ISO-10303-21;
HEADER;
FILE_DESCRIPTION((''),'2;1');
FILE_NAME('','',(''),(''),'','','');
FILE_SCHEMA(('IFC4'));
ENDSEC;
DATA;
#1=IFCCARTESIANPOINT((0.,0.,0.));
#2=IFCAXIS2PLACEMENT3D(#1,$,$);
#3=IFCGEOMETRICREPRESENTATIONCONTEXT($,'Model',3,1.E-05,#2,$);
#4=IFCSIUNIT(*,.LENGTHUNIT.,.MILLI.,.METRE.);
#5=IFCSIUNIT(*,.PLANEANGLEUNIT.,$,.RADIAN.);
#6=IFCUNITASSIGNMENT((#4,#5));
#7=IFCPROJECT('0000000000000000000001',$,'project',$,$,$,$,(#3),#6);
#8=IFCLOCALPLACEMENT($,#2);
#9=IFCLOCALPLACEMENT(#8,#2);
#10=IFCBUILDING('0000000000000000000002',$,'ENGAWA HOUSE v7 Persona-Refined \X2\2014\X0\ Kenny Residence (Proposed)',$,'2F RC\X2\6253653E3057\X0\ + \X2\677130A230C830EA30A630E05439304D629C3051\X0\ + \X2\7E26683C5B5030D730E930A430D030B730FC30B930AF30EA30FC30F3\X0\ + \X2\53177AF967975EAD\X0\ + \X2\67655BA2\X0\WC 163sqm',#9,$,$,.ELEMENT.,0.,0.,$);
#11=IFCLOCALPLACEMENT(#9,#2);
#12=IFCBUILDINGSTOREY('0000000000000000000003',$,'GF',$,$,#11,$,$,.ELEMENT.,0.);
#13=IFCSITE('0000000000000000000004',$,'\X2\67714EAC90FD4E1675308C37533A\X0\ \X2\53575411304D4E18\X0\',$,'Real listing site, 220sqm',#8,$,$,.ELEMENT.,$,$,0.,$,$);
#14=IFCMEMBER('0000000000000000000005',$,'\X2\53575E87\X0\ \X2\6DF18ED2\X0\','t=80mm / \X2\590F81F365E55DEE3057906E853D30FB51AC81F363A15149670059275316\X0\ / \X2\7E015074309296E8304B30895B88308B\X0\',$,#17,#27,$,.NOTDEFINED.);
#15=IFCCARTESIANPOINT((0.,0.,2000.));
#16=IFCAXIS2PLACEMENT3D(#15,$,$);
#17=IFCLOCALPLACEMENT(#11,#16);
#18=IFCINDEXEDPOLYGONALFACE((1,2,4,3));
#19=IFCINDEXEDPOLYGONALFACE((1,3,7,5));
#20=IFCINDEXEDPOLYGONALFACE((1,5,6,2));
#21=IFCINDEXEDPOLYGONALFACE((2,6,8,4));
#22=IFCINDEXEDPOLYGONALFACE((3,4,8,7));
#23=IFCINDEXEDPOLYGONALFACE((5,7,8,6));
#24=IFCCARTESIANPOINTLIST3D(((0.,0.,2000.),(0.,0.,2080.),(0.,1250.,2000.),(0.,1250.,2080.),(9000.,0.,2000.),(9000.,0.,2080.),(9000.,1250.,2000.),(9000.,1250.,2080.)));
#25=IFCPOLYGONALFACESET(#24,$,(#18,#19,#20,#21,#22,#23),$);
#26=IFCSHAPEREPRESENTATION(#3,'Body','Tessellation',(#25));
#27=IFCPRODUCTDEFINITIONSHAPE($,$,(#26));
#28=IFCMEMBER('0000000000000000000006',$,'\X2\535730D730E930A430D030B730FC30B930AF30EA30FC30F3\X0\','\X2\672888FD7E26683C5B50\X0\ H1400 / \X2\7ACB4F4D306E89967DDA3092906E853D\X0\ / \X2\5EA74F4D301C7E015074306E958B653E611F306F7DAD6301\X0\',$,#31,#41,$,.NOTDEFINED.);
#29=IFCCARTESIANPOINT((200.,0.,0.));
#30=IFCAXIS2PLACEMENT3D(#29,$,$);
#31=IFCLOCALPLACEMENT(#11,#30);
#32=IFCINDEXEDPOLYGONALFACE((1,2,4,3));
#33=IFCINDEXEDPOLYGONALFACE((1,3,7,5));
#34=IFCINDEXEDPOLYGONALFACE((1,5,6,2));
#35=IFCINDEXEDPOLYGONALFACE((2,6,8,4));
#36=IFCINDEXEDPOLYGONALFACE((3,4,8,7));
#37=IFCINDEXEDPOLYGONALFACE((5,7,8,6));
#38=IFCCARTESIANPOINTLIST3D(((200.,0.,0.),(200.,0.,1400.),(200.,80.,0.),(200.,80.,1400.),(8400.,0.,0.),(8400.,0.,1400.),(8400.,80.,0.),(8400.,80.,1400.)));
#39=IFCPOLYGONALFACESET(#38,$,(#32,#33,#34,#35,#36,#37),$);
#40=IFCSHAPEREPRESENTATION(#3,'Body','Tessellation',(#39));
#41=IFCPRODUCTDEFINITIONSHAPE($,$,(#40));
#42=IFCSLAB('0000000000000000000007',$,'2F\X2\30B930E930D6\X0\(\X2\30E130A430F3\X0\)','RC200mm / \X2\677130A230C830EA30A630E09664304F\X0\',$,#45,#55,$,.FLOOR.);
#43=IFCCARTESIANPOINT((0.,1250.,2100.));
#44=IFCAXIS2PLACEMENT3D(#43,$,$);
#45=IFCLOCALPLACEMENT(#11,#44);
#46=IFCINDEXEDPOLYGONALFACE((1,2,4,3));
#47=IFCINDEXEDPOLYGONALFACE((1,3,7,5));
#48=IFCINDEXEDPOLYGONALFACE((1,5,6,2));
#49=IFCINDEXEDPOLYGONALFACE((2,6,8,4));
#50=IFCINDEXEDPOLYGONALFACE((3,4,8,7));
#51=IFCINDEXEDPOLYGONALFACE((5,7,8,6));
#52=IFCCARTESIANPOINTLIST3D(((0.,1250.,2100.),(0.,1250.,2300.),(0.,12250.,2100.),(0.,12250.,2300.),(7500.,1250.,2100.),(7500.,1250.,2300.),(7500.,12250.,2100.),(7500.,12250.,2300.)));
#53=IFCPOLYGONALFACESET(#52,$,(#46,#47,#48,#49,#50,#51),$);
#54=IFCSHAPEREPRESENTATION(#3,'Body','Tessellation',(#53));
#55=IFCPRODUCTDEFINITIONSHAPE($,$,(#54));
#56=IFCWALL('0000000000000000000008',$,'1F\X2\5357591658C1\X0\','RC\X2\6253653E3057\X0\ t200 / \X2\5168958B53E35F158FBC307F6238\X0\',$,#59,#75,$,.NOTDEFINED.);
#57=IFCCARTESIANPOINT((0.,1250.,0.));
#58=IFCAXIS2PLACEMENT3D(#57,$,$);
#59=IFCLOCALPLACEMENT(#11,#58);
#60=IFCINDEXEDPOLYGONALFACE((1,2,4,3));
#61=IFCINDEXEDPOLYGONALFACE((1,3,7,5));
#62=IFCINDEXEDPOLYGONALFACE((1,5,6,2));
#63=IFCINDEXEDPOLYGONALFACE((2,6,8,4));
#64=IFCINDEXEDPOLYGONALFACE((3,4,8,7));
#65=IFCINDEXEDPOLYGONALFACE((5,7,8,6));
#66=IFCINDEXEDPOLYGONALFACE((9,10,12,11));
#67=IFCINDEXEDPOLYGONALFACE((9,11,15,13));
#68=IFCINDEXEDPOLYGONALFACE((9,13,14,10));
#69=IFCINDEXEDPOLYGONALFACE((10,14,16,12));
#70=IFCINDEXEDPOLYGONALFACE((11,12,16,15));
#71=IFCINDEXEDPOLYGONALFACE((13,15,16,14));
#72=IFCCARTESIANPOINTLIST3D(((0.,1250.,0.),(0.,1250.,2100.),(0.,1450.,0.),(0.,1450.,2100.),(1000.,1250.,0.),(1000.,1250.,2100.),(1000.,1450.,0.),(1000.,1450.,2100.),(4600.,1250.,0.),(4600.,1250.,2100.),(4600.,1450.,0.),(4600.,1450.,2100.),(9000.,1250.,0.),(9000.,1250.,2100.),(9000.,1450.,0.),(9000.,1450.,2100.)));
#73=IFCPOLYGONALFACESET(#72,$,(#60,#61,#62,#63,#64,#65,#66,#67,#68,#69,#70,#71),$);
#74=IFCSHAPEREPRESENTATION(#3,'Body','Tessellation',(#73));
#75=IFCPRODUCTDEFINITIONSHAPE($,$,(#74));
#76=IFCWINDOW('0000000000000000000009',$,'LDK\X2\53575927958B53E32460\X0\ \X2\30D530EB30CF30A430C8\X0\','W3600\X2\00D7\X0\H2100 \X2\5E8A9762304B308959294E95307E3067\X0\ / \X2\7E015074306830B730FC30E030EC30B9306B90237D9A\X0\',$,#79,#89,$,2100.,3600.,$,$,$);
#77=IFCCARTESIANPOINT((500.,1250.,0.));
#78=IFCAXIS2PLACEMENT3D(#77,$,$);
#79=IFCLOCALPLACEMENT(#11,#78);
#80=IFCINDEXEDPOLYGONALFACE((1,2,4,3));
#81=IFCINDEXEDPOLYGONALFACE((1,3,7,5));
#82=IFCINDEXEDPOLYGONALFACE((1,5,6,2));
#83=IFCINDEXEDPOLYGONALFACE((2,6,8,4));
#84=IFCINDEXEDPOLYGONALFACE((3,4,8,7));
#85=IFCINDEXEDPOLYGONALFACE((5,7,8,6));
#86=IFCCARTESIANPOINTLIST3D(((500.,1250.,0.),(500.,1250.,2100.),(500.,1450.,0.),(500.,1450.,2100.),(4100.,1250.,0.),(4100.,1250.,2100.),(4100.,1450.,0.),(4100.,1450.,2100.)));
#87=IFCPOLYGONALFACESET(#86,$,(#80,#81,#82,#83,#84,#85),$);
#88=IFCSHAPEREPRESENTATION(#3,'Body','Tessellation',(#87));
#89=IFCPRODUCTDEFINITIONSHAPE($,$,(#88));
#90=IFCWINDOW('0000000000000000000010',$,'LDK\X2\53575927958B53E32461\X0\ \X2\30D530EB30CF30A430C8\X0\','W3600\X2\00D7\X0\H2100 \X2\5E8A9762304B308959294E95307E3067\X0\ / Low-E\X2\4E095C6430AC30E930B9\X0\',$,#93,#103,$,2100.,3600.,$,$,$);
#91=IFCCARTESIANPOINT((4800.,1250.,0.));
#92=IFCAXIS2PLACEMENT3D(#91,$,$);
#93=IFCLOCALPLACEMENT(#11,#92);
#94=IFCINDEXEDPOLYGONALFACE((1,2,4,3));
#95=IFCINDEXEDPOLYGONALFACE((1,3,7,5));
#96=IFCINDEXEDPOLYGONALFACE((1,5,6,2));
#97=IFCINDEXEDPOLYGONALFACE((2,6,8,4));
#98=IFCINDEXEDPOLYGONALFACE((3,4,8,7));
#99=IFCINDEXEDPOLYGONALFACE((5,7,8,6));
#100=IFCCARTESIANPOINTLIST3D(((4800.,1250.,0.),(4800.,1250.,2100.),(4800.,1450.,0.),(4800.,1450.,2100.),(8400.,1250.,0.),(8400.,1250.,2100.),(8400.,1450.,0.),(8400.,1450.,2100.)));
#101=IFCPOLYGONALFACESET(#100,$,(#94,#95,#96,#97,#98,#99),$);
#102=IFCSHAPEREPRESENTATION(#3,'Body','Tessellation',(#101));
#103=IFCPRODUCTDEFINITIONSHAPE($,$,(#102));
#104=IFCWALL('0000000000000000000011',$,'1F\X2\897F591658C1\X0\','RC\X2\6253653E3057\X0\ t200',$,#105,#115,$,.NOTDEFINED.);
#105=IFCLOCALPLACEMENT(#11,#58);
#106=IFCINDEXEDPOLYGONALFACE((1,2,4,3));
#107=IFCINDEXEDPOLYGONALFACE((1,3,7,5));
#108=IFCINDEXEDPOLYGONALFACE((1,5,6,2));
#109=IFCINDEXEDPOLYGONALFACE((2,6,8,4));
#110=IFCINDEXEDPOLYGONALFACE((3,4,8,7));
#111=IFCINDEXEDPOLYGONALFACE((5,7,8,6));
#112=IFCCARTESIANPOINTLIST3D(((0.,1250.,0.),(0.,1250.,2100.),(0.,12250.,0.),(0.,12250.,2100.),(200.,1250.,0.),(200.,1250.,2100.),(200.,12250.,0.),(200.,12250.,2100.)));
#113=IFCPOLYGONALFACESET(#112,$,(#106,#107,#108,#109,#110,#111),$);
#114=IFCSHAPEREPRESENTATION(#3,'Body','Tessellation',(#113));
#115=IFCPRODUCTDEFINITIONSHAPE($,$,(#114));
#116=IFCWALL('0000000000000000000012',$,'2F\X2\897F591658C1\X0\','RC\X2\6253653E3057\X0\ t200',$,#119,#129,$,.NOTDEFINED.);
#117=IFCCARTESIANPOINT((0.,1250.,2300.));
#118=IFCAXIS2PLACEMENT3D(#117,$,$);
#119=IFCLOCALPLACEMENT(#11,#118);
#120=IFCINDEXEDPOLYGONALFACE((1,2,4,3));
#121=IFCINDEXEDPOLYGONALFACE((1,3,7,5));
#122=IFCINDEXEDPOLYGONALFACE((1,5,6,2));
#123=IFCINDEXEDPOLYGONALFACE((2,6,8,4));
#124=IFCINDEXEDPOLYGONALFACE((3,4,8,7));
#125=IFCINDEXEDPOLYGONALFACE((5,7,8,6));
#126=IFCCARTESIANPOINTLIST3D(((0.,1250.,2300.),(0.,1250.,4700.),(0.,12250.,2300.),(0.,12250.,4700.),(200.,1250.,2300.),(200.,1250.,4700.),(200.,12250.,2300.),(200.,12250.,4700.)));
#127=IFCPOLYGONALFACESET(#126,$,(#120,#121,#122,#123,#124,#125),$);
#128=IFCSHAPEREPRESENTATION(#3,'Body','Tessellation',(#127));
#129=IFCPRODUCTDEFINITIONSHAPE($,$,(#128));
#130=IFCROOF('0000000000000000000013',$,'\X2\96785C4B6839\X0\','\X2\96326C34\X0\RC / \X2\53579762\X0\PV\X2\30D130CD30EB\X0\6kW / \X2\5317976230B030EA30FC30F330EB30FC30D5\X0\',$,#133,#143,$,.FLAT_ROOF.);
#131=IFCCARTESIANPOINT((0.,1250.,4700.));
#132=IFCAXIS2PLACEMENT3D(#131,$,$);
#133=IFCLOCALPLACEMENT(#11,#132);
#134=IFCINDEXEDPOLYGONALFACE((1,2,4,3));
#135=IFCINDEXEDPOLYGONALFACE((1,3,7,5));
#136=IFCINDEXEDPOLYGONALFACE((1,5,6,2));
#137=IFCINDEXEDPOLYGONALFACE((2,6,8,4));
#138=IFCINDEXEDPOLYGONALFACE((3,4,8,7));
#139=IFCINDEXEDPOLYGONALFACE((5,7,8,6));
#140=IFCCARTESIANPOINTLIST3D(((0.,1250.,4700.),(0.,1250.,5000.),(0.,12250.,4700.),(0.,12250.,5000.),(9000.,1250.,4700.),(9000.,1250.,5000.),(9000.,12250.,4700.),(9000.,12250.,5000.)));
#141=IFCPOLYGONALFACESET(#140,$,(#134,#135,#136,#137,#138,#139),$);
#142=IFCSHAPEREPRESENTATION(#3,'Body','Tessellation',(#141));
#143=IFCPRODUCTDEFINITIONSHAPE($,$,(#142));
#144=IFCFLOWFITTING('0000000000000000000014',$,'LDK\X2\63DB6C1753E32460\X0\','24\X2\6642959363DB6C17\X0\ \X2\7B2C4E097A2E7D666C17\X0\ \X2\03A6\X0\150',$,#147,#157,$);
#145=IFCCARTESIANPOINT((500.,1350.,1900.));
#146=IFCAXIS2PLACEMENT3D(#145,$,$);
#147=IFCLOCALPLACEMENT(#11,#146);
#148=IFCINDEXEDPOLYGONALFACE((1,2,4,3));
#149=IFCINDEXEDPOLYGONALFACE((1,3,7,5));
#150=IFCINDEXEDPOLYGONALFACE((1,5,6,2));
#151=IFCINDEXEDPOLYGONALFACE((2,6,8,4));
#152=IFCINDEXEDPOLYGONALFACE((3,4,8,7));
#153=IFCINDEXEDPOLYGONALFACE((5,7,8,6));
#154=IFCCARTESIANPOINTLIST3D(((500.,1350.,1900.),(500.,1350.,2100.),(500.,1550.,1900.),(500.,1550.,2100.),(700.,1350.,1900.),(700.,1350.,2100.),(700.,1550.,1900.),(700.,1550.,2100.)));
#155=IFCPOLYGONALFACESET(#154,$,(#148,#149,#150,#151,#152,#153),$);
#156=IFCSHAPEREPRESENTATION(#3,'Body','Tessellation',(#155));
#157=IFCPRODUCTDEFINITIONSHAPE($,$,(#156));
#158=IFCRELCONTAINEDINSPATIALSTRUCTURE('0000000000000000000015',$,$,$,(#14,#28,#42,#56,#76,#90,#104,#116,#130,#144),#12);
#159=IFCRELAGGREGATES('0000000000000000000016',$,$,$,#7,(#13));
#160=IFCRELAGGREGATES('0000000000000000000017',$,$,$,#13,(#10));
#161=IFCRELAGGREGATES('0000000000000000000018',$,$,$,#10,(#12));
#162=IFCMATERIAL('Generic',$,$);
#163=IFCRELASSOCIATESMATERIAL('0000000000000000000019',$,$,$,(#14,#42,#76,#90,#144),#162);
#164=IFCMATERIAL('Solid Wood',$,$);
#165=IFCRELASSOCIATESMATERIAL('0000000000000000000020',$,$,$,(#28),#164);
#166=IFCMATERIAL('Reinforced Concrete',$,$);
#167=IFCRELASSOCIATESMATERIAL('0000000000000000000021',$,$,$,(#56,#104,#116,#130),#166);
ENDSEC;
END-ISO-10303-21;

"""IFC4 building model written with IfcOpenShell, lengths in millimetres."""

from ifc_helpers import new_model, si_unit, frame, frame_2d, origin, place, context, project, spatial, rectangle, extrude, material, element, fill, save


model = new_model("IFC4")

# Units and contexts
model_context = context("Model", 3, precision=1e-05, world=origin())
ifc_project = project(units=[si_unit("LENGTHUNIT", "METRE", prefix="MILLI"), si_unit("PLANEANGLEUNIT", "RADIAN")], contexts=[model_context])

# Site, building, storey
site_placement = place(None, origin())
site = spatial("IfcSite", under=ifc_project, at=site_placement, Name="東京都世田谷区 南向き丘", ObjectType="Real listing site, 220sqm", CompositionType="ELEMENT", RefElevation=0.0)
building_placement = place(site_placement, origin())
building = spatial("IfcBuilding", under=site, at=building_placement, Name="ENGAWA HOUSE v7 Persona-Refined — Kenny Residence (Proposed)", ObjectType="2F RC打放し + 東アトリウム吹き抜け + 縦格子プライバシースクリーン + 北竹林庭 + 来客WC 163sqm", CompositionType="ELEMENT", ElevationOfRefHeight=0.0, ElevationOfTerrain=0.0)
storey_placement = place(building_placement, origin())
storey = spatial("IfcBuildingStorey", under=building, at=storey_placement, Name="GF", CompositionType="ELEMENT", Elevation=0.0)

# Members
ifc_material_1 = material(Name="Generic")
member_1_placement = place(storey_placement, frame((0.0, 0.0, 2000.0)))
element("IfcMember", 1, at=member_1_placement, inside=storey, material=ifc_material_1, Name="南庇 深軒", Description="t=80mm / 夏至日差し遮蔽・冬至採光最大化 / 縁側を雨から守る", PredefinedType="NOTDEFINED", context=model_context, shape_type="SweptSolid", body=[
    extrude(rectangle(XDim=9000.0, YDim=1250.0, at=frame_2d((4500.0, 625.0))), frame((0.0, 0.0, 2000.0)), (0.0, 0.0, 1.0), 80.0),
])
ifc_material_2 = material(Name="Solid Wood")
member_2_placement = place(storey_placement, frame((200.0, 0.0, 0.0)))
element("IfcMember", 2, at=member_2_placement, inside=storey, material=ifc_material_2, Name="南プライバシースクリーン", Description="木製縦格子 H1400 / 立位の視線を遮蔽 / 座位〜縁側の開放感は維持", PredefinedType="NOTDEFINED", context=model_context, shape_type="SweptSolid", body=[
    extrude(rectangle(XDim=8200.0, YDim=80.0, at=frame_2d((4100.0, 40.0))), frame((200.0, 0.0, 0.0)), (0.0, 0.0, 1.0), 1400.0),
])

# Slab
ifc_material_3 = material(Name="Reinforced Concrete")
slab_1_placement = place(storey_placement, frame((0.0, 1250.0, 2100.0)))
element("IfcSlab", 3, at=slab_1_placement, inside=storey, material=ifc_material_1, Name="2Fスラブ(メイン)", Description="RC200mm / 東アトリウム除く", PredefinedType="FLOOR", context=model_context, shape_type="SweptSolid", body=[
    extrude(rectangle(XDim=7500.0, YDim=11000.0, at=frame_2d((3750.0, 5500.0))), frame((0.0, 1250.0, 2100.0)), (0.0, 0.0, 1.0), 200.0),
])

# Wall, openings, windows
wall_1_placement = place(storey_placement, frame((0.0, 1250.0, 0.0)))
wall_1 = element("IfcWall", 4, at=wall_1_placement, inside=storey, material=ifc_material_3, Name="1F南外壁", Description="RC打放し t200 / 全開口引込み戸", PredefinedType="NOTDEFINED", context=model_context, shape_type="SweptSolid", body=[
    extrude(rectangle(XDim=9000.0, YDim=200.0, at=frame_2d((4500.0, 100.0))), frame((0.0, 1250.0, 0.0)), (0.0, 0.0, 1.0), 2100.0),
])
opening_1_placement = place(storey_placement, frame((500.0, 1250.0, 0.0)))
opening_1 = element("IfcOpeningElement", 5, at=opening_1_placement, cuts=wall_1, PredefinedType="NOTDEFINED", context=model_context, shape_type="SweptSolid", body=[
    extrude(rectangle(XDim=3600.0, YDim=200.0, at=frame_2d((1800.0, 100.0))), frame((500.0, 1250.0, 0.0)), (0.0, 0.0, 1.0), 2100.0),
])
opening_2_placement = place(storey_placement, frame((4800.0, 1250.0, 0.0)))
opening_2 = element("IfcOpeningElement", 6, at=opening_2_placement, cuts=wall_1, PredefinedType="NOTDEFINED", context=model_context, shape_type="SweptSolid", body=[
    extrude(rectangle(XDim=3600.0, YDim=200.0, at=frame_2d((1800.0, 100.0))), frame((4800.0, 1250.0, 0.0)), (0.0, 0.0, 1.0), 2100.0),
])
window_1_placement = place(storey_placement, frame((500.0, 1250.0, 0.0)))
window_1 = element("IfcWindow", 7, at=window_1_placement, inside=storey, material=ifc_material_1, Name="LDK南大開口① フルハイト", Description="W3600×H2100 床面から天井まで / 縁側とシームレスに連続", OverallHeight=2100.0, OverallWidth=3600.0, context=model_context, shape_type="SweptSolid", body=[
    extrude(rectangle(XDim=3600.0, YDim=200.0, at=frame_2d((1800.0, 100.0))), frame((500.0, 1250.0, 0.0)), (0.0, 0.0, 1.0), 2100.0),
])
fill(opening_1, window_1)
window_2_placement = place(storey_placement, frame((4800.0, 1250.0, 0.0)))
window_2 = element("IfcWindow", 8, at=window_2_placement, inside=storey, material=ifc_material_1, Name="LDK南大開口② フルハイト", Description="W3600×H2100 床面から天井まで / Low-E三層ガラス", OverallHeight=2100.0, OverallWidth=3600.0, context=model_context, shape_type="SweptSolid", body=[
    extrude(rectangle(XDim=3600.0, YDim=200.0, at=frame_2d((1800.0, 100.0))), frame((4800.0, 1250.0, 0.0)), (0.0, 0.0, 1.0), 2100.0),
])
fill(opening_2, window_2)

# Wall
wall_2_placement = place(storey_placement, frame((0.0, 1250.0, 0.0)))
element("IfcWall", 9, at=wall_2_placement, inside=storey, material=ifc_material_3, Name="1F西外壁", Description="RC打放し t200", PredefinedType="NOTDEFINED", context=model_context, shape_type="SweptSolid", body=[
    extrude(rectangle(XDim=200.0, YDim=11000.0, at=frame_2d((100.0, 5500.0))), frame((0.0, 1250.0, 0.0)), (0.0, 0.0, 1.0), 2100.0),
])

# Wall
wall_3_placement = place(storey_placement, frame((0.0, 1250.0, 2300.0)))
element("IfcWall", 10, at=wall_3_placement, inside=storey, material=ifc_material_3, Name="2F西外壁", Description="RC打放し t200", PredefinedType="NOTDEFINED", context=model_context, shape_type="SweptSolid", body=[
    extrude(rectangle(XDim=200.0, YDim=11000.0, at=frame_2d((100.0, 5500.0))), frame((0.0, 1250.0, 2300.0)), (0.0, 0.0, 1.0), 2400.0),
])

# Roof
roof_placement = place(storey_placement, frame((0.0, 1250.0, 4700.0)))
element("IfcRoof", 11, at=roof_placement, inside=storey, material=ifc_material_3, Name="陸屋根", Description="防水RC / 南面PVパネル6kW / 北面グリーンルーフ", PredefinedType="FLAT_ROOF", context=model_context, shape_type="SweptSolid", body=[
    extrude(rectangle(XDim=9000.0, YDim=11000.0, at=frame_2d((4500.0, 5500.0))), frame((0.0, 1250.0, 4700.0)), (0.0, 0.0, 1.0), 300.0),
])

# Flow fitting
flow_fitting_placement = place(storey_placement, frame((500.0, 1350.0, 1900.0)))
element("IfcFlowFitting", 12, at=flow_fitting_placement, inside=storey, material=ifc_material_1, Name="LDK換気口①", Description="24時間換気 第三種給気 Φ150", context=model_context, shape_type="SweptSolid", body=[
    extrude(rectangle(XDim=200.0, YDim=200.0, at=frame_2d((100.0, 100.0))), frame((500.0, 1350.0, 1900.0)), (0.0, 0.0, 1.0), 200.0),
])

save(model, "model.ifc")
